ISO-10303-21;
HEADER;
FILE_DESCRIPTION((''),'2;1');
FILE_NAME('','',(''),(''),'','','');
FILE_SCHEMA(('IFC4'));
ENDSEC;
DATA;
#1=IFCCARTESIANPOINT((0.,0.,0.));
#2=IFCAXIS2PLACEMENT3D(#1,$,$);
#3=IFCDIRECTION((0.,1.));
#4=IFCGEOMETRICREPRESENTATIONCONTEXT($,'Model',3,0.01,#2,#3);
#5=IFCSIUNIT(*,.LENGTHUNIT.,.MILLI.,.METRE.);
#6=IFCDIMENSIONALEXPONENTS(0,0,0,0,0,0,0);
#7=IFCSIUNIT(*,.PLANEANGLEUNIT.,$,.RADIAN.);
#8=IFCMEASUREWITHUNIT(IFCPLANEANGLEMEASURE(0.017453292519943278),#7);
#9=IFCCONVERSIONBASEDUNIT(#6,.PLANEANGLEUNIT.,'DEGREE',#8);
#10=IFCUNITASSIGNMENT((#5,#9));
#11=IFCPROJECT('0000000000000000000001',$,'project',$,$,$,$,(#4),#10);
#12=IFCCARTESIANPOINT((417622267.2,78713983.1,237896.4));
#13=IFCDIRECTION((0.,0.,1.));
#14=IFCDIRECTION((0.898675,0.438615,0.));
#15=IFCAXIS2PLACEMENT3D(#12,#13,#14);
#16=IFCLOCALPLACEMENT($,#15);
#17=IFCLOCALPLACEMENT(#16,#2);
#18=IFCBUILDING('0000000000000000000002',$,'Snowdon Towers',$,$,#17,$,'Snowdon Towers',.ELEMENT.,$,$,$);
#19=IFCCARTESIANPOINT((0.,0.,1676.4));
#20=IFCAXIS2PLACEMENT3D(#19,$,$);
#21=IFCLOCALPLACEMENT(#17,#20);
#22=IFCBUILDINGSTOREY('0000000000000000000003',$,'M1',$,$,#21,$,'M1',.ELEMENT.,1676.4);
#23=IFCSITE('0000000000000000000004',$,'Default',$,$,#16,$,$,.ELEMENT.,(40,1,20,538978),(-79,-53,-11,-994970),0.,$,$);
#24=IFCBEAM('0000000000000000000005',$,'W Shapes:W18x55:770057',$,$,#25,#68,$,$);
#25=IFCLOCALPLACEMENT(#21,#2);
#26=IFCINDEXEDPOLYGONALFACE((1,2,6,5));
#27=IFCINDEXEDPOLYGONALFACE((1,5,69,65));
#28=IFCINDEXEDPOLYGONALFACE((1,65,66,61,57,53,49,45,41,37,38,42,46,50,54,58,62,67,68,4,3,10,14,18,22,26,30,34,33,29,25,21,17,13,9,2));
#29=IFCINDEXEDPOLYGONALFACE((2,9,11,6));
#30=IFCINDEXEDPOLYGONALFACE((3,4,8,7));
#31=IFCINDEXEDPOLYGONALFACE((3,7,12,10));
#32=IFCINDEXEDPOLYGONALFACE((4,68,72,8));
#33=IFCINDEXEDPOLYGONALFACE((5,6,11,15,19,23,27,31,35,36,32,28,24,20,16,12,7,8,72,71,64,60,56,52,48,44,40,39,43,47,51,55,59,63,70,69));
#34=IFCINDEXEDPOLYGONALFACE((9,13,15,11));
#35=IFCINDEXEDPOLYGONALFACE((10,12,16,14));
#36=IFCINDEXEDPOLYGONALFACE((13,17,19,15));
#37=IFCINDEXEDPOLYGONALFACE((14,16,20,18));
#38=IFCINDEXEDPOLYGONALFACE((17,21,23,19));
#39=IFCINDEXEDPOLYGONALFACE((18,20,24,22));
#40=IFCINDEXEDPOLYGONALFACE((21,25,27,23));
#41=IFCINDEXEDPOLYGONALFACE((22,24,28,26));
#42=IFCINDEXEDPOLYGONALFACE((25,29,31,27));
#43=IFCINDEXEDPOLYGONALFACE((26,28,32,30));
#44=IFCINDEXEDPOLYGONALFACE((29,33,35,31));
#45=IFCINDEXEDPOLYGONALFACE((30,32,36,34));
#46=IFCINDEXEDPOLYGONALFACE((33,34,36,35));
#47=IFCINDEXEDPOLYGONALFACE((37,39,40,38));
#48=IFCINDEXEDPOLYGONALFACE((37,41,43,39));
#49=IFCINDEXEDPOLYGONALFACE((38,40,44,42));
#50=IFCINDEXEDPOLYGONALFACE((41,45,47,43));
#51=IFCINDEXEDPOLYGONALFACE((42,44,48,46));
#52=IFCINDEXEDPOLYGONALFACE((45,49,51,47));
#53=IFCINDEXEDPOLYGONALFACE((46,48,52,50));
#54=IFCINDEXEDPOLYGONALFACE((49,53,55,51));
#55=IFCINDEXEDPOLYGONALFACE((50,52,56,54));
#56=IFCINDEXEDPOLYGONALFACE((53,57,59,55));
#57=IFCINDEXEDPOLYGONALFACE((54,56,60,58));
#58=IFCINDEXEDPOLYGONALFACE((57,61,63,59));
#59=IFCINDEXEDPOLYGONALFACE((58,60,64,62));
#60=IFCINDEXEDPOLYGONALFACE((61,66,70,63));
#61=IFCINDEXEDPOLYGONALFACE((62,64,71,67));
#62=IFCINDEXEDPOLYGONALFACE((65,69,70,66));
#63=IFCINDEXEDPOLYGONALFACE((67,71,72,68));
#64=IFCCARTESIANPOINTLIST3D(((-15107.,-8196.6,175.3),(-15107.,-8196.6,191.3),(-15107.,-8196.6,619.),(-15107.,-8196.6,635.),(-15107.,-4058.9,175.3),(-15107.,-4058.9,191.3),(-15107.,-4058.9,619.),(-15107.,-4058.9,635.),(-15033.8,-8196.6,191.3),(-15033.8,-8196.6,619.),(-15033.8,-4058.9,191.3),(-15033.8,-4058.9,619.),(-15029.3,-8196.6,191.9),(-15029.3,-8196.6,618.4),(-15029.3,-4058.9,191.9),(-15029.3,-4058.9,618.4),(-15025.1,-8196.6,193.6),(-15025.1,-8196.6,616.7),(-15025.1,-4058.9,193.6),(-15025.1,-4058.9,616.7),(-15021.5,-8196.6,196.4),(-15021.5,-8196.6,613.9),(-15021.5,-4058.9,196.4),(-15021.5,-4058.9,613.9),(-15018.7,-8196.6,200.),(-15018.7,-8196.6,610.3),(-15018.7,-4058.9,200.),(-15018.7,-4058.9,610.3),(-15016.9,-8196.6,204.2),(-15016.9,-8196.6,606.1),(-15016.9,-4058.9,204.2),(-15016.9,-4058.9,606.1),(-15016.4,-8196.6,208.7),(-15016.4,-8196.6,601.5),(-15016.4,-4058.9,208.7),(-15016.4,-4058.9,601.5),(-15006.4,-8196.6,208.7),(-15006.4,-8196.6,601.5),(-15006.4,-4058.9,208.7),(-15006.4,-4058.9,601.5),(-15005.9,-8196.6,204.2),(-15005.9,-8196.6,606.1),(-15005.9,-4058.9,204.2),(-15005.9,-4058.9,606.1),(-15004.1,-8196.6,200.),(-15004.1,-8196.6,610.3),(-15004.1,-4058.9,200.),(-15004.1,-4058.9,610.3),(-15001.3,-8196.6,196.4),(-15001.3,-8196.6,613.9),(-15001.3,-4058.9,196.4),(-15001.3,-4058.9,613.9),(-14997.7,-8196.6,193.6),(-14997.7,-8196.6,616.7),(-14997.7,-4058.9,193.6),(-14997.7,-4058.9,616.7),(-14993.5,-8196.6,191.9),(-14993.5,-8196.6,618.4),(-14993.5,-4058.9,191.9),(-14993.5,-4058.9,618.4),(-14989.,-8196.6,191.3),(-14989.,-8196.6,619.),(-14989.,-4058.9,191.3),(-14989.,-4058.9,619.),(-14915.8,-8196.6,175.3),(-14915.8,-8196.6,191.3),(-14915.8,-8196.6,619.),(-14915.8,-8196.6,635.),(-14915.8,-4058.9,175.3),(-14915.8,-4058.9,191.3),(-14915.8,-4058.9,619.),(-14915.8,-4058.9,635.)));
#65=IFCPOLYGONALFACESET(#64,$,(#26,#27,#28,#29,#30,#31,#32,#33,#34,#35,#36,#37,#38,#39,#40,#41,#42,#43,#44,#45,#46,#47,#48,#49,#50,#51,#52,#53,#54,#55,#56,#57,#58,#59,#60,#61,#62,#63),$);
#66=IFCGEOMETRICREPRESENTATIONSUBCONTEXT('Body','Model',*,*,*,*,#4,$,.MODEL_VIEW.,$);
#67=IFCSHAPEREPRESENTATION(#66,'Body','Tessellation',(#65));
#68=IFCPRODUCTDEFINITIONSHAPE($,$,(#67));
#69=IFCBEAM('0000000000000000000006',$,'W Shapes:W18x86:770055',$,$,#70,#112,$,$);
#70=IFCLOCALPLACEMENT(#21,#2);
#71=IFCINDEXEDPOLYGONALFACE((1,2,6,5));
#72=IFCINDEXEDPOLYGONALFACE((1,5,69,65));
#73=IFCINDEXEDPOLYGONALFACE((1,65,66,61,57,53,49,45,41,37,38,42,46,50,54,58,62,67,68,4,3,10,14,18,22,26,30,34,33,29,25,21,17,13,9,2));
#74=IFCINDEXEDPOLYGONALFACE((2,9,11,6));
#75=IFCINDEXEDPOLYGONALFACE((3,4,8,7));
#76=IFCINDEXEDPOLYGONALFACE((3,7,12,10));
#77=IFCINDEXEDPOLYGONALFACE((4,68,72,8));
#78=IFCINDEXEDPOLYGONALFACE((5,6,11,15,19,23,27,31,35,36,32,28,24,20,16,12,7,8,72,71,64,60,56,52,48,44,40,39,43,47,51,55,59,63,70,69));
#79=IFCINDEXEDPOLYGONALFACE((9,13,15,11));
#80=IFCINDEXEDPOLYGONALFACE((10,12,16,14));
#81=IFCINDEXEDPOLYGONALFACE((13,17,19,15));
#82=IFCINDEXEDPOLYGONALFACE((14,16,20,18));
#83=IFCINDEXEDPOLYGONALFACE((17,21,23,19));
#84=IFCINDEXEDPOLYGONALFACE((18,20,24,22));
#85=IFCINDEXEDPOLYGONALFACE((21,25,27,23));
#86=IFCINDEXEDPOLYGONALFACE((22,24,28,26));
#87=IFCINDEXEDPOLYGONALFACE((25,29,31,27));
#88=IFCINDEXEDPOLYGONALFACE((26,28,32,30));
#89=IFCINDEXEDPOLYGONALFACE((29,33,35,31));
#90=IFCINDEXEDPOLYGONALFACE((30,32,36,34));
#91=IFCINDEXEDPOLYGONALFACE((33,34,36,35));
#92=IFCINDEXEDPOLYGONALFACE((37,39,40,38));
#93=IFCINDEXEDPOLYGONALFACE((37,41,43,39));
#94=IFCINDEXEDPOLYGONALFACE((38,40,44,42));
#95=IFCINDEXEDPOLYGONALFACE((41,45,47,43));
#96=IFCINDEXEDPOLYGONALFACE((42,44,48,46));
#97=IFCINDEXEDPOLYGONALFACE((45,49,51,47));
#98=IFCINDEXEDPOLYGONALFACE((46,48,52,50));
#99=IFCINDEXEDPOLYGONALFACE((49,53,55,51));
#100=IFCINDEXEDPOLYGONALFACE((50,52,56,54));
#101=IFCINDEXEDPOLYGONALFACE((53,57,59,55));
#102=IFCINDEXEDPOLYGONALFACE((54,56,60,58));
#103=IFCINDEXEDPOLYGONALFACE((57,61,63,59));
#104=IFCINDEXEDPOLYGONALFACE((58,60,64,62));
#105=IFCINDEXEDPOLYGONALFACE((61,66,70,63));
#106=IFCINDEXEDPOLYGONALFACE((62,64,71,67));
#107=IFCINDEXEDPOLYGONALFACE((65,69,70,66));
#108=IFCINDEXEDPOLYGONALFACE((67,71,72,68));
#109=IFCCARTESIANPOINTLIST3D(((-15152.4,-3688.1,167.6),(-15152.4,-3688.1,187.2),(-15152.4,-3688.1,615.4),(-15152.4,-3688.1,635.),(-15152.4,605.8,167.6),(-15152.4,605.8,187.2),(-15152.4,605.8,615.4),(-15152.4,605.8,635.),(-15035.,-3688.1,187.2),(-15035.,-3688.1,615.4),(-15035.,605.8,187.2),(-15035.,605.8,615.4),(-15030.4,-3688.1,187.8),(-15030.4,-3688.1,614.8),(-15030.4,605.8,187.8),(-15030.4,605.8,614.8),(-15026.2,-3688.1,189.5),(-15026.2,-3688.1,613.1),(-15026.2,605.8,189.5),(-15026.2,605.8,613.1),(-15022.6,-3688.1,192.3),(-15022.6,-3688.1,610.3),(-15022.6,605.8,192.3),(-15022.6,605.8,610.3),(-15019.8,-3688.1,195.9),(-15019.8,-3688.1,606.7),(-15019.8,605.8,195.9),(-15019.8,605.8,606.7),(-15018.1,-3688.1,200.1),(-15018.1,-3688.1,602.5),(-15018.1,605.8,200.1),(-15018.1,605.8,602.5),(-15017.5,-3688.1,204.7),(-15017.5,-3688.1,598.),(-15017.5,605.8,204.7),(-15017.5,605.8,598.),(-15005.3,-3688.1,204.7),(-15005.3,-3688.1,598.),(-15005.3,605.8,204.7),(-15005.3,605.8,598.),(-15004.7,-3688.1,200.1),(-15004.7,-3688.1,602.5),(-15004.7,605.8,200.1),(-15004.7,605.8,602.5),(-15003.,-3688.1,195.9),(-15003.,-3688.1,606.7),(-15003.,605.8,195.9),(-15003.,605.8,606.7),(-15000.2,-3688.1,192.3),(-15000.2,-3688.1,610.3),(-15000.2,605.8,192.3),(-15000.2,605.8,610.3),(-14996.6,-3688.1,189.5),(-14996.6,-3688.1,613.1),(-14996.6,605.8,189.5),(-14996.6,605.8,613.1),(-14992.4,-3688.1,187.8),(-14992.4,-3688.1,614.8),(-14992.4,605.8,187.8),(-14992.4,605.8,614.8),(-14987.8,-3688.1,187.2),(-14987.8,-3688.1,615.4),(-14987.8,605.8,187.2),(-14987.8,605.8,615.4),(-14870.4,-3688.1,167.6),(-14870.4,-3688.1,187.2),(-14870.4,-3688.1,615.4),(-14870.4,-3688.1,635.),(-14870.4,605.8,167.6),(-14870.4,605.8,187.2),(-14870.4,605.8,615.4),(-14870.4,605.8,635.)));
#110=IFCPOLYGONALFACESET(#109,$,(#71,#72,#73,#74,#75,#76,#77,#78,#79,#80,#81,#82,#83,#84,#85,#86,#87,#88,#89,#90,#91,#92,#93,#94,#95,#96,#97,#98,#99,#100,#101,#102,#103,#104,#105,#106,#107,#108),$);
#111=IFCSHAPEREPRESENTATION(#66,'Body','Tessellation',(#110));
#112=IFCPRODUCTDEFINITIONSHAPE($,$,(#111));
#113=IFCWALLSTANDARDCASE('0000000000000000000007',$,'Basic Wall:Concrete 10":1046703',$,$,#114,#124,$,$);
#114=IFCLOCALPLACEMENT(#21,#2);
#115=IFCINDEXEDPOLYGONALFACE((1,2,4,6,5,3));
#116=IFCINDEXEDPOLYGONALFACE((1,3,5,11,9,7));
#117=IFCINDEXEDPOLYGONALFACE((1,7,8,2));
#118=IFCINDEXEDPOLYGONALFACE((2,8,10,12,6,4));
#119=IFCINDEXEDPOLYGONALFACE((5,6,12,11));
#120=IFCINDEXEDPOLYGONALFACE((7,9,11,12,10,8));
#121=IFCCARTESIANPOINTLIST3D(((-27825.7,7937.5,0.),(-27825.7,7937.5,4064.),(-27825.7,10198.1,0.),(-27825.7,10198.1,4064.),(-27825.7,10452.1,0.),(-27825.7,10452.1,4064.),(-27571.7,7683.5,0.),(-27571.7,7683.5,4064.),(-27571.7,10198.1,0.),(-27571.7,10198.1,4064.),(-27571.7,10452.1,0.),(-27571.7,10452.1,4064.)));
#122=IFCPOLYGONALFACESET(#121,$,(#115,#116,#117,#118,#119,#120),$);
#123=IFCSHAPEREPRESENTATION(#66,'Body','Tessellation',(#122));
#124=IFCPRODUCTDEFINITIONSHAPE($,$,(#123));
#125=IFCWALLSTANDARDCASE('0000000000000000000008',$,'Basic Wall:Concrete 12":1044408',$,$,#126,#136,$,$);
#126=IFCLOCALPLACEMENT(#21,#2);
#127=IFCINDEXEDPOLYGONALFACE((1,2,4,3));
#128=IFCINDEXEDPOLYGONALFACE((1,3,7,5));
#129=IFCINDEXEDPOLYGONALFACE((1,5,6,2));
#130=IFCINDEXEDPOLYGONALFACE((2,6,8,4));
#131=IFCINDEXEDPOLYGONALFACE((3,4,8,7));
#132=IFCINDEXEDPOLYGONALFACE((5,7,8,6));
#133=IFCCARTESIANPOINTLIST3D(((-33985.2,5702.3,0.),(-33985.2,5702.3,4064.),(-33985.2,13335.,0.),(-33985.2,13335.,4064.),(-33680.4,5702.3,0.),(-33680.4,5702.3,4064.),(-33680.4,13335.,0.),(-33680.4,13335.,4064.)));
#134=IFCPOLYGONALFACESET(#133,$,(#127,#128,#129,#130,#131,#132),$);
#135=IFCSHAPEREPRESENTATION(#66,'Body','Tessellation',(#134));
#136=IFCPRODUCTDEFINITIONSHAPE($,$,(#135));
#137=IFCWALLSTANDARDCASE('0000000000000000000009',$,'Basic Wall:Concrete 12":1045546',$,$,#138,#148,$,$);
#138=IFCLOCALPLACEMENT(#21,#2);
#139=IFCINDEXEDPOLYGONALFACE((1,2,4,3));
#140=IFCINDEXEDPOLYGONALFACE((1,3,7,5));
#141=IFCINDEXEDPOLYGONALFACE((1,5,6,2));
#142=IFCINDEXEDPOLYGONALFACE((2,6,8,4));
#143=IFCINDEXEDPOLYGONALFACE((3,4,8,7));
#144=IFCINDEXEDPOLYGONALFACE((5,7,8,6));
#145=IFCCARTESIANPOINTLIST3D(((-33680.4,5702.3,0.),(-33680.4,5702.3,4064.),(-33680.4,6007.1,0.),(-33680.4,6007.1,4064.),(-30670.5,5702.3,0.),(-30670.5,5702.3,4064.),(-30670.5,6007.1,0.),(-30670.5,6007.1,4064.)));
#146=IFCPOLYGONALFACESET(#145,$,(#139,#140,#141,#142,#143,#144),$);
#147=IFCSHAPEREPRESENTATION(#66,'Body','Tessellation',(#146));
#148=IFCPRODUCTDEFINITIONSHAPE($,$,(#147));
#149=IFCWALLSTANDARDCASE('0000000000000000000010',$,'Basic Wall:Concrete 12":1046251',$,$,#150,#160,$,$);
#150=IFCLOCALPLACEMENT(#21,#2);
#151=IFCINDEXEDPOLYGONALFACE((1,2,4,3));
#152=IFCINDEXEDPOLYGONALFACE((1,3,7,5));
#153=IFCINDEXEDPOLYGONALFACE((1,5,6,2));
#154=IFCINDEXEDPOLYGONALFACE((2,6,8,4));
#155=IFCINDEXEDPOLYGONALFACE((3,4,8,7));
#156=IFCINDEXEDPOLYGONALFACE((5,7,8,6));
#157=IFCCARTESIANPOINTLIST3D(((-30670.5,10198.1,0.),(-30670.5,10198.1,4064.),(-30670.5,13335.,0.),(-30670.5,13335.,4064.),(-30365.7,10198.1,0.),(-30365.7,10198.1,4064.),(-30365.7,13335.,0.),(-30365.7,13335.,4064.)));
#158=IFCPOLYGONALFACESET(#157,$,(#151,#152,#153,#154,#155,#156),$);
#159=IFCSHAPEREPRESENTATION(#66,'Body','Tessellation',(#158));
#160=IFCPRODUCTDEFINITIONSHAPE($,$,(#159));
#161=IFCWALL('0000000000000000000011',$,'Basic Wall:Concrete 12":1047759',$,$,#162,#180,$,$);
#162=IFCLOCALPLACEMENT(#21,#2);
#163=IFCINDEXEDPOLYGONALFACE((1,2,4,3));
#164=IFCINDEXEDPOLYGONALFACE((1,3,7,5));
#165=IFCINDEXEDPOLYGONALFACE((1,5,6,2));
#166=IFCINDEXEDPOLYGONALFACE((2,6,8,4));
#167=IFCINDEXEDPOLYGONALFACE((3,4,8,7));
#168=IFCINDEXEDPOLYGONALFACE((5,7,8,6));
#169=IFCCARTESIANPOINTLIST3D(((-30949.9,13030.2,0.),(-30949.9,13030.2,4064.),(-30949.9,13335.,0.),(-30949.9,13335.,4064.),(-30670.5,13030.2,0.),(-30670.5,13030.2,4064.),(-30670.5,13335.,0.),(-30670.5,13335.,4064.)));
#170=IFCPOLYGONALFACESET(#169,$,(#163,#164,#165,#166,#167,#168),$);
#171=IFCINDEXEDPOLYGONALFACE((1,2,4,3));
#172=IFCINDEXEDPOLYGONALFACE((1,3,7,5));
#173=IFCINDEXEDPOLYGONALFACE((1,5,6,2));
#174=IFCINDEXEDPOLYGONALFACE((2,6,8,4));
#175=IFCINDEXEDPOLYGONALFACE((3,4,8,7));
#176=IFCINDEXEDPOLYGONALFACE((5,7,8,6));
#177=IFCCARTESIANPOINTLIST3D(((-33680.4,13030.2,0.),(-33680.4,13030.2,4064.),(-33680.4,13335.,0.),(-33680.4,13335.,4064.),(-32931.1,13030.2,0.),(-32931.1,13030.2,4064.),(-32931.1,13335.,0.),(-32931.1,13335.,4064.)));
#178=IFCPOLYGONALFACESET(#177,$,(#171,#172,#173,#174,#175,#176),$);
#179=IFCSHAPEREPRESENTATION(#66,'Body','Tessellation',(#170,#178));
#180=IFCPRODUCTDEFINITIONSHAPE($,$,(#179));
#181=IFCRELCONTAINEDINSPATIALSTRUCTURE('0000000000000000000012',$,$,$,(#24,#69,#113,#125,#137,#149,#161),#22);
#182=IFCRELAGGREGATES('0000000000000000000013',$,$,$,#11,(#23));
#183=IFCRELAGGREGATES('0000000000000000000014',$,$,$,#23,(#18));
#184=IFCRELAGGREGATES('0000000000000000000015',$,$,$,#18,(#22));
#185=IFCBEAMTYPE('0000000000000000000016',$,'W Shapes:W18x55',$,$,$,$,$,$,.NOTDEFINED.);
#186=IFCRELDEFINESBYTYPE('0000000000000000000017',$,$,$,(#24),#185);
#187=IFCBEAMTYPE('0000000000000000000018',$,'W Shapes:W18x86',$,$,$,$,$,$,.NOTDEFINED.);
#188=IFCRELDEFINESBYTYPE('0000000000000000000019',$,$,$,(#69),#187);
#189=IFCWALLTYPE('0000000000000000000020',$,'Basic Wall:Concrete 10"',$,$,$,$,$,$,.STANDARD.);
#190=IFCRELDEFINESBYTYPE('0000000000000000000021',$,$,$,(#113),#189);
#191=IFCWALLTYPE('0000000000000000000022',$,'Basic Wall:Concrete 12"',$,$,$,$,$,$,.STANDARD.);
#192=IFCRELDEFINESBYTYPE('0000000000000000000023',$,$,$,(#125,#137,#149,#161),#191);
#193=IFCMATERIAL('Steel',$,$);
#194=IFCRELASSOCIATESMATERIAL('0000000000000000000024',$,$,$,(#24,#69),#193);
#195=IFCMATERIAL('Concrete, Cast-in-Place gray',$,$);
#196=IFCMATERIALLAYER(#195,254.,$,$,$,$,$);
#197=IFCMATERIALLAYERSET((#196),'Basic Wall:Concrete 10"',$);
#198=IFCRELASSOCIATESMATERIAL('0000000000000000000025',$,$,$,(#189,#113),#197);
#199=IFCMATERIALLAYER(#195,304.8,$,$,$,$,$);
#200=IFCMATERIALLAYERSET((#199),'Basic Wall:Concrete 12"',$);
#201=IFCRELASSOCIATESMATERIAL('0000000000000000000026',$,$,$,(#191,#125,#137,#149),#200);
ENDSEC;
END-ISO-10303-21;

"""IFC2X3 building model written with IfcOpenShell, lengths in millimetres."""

from ifc_helpers import new_model, entity, si_unit, converted_unit, direction, frame, frame_2d, origin, place, context, subcontext, project, spatial, polyline, rectangle, i_section, outline, extrude, material, layer, layer_set, layer_usage, type_object, element, save


model = new_model("IFC2X3")

# Units and contexts
model_context = context("Model", 3, precision=0.01, world=origin(), true_north=direction((0.0, 1.0)))
body_context = subcontext(model_context, "Body", "Model", "MODEL_VIEW")
ifc_project = project(units=[si_unit("LENGTHUNIT", "METRE", prefix="MILLI"), converted_unit("PLANEANGLEUNIT", "DEGREE", entity("IfcPlaneAngleMeasure", 0.017453292519943278), si_unit("PLANEANGLEUNIT", "RADIAN"), dimensions=[0, 0, 0, 0, 0, 0, 0])], contexts=[model_context])

# Site, building, storey
site_placement = place(None, frame((417622267.2, 78713983.1, 237896.4), z_axis=(0.0, 0.0, 1.0), x_axis=(0.898675, 0.438615, 0.0)))
site = spatial("IfcSite", under=ifc_project, at=site_placement, Name="Default", CompositionType="ELEMENT", RefLatitude=(40, 1, 20, 538978), RefLongitude=(-79, -53, -11, -994970), RefElevation=0.0)
building_placement = place(site_placement, origin())
building = spatial("IfcBuilding", under=site, at=building_placement, Name="Snowdon Towers", LongName="Snowdon Towers", CompositionType="ELEMENT")
storey_placement = place(building_placement, frame((0.0, 0.0, 1676.4)))
storey = spatial("IfcBuildingStorey", under=building, at=storey_placement, Name="M1", LongName="M1", CompositionType="ELEMENT", Elevation=1676.4)

# Shared definitions
ifc_material_1 = material(Name="Steel")

# Beams
beam_type_1 = type_object("IfcBeamType", Name="W Shapes:W18x55", PredefinedType="NOTDEFINED")
beam_1_placement = place(storey_placement, frame((-15011.4, -3873.5, 635.0), z_axis=(0.0, 0.0, 1.0), x_axis=(0.0, -1.0, 0.0)))
element("IfcBeam", 1, at=beam_1_placement, inside=storey, type_object=beam_type_1, material=ifc_material_1, Name="W Shapes:W18x55:770057", context=body_context, shape_type="SweptSolid", body=[
    extrude(i_section(OverallWidth=191.3, OverallDepth=459.7, WebThickness=9.9, FlangeThickness=16.0, FilletRadius=17.5, at=frame_2d((0.0, 0.0), x_axis=(0.0, 1.0))), frame((185.4, 0.0, -229.9), z_axis=(1.0, 0.0, 0.0), x_axis=(0.0, 0.0, -1.0)), (0.0, 0.0, 1.0), 4137.7),
])
beam_type_2 = type_object("IfcBeamType", Name="W Shapes:W18x86", PredefinedType="NOTDEFINED")
beam_2_placement = place(storey_placement, frame((-15011.4, 762.0, 635.0), z_axis=(0.0, 0.0, 1.0), x_axis=(0.0, -1.0, 0.0)))
element("IfcBeam", 2, at=beam_2_placement, inside=storey, type_object=beam_type_2, material=ifc_material_1, Name="W Shapes:W18x86:770055", context=body_context, shape_type="SweptSolid", body=[
    extrude(i_section(OverallWidth=281.9, OverallDepth=467.4, WebThickness=12.2, FlangeThickness=19.6, FilletRadius=17.5, at=frame_2d((0.0, 0.0), x_axis=(0.0, 1.0))), frame((156.2, 0.0, -233.7), z_axis=(1.0, 0.0, 0.0), x_axis=(0.0, 0.0, -1.0)), (0.0, 0.0, 1.0), 4293.9),
])

# Walls
ifc_material_2 = material(Name="Concrete, Cast-in-Place gray")
ifc_layer_1 = layer(ifc_material_2, 254.0)
ifc_layer_set_1 = layer_set([ifc_layer_1], Name="Basic Wall:Concrete 10\"")
ifc_layer_usage_1 = layer_usage(ifc_layer_set_1, "AXIS2", "POSITIVE", -127.0)
wall_type_1 = type_object("IfcWallType", Name="Basic Wall:Concrete 10\"", PredefinedType="STANDARD", material=ifc_layer_set_1)
wall_1_placement = place(storey_placement, frame((-27698.7, 10452.1, 0.0), z_axis=(0.0, 0.0, 1.0), x_axis=(0.0, -1.0, 0.0)))
element("IfcWallStandardCase", 3, at=wall_1_placement, inside=storey, type_object=wall_type_1, material=ifc_layer_usage_1, Name="Basic Wall:Concrete 10\":1046703", context=body_context, shape_type="SweptSolid", body=[
    extrude(outline(polyline([(2514.6, -127.0), (2768.6, 127.0), (254.0, 127.0), (0.0, 127.0), (0.0, -127.0), (254.0, -127.0), (2514.6, -127.0)])), origin(), (0.0, 0.0, 1.0), 4064.0),
])
ifc_layer_2 = layer(ifc_material_2, 304.8)
ifc_layer_set_2 = layer_set([ifc_layer_2], Name="Basic Wall:Concrete 12\"")
ifc_layer_usage_2 = layer_usage(ifc_layer_set_2, "AXIS2", "POSITIVE", -152.4)
wall_type_2 = type_object("IfcWallType", Name="Basic Wall:Concrete 12\"", PredefinedType="STANDARD", material=ifc_layer_set_2)
wall_2_placement = place(storey_placement, frame((-33832.8, 13335.0, 0.0), z_axis=(0.0, 0.0, 1.0), x_axis=(0.0, -1.0, 0.0)))
element("IfcWallStandardCase", 4, at=wall_2_placement, inside=storey, type_object=wall_type_2, material=ifc_layer_usage_2, Name="Basic Wall:Concrete 12\":1044408", context=body_context, shape_type="SweptSolid", body=[
    extrude(rectangle(XDim=7632.7, YDim=304.8, at=frame_2d((3816.4, 0.0), x_axis=(-1.0, 0.0))), origin(), (0.0, 0.0, 1.0), 4064.0),
])
ifc_layer_usage_3 = layer_usage(ifc_layer_set_2, "AXIS2", "POSITIVE", -152.4)
wall_3_placement = place(storey_placement, frame((-30670.5, 5854.7, 0.0), z_axis=(0.0, 0.0, 1.0), x_axis=(-1.0, 0.0, 0.0)))
element("IfcWallStandardCase", 5, at=wall_3_placement, inside=storey, type_object=wall_type_2, material=ifc_layer_usage_3, Name="Basic Wall:Concrete 12\":1045546", context=body_context, shape_type="SweptSolid", body=[
    extrude(rectangle(XDim=3009.9, YDim=304.8, at=frame_2d((1505.0, 0.0), x_axis=(-1.0, 0.0))), origin(), (0.0, 0.0, 1.0), 4064.0),
])
ifc_layer_usage_4 = layer_usage(ifc_layer_set_2, "AXIS2", "NEGATIVE", 152.4)
wall_4_placement = place(storey_placement, frame((-30518.1, 10198.1, 0.0), z_axis=(0.0, 0.0, 1.0), x_axis=(0.0, 1.0, 0.0)))
element("IfcWallStandardCase", 6, at=wall_4_placement, inside=storey, type_object=wall_type_2, material=ifc_layer_usage_4, Name="Basic Wall:Concrete 12\":1046251", context=body_context, shape_type="SweptSolid", body=[
    extrude(rectangle(XDim=3136.9, YDim=304.8, at=frame_2d((1568.5, 0.0), x_axis=(-1.0, 0.0))), origin(), (0.0, 0.0, 1.0), 4064.0),
])
wall_5_placement = place(storey_placement, frame((-30670.5, 13182.6, 0.0), z_axis=(0.0, 0.0, 1.0), x_axis=(-1.0, 0.0, 0.0)))
element("IfcWall", 7, at=wall_5_placement, inside=storey, type_object=wall_type_2, Name="Basic Wall:Concrete 12\":1047759", context=body_context, shape_type="SweptSolid", body=[
    extrude(rectangle(XDim=304.8, YDim=279.4, at=frame_2d((0.0, 0.0), x_axis=(1.0, 0.0))), frame((139.7, 0.0, 0.0), z_axis=(0.0, 0.0, 1.0), x_axis=(0.0, 1.0, 0.0)), (0.0, 0.0, 1.0), 4064.0),
    extrude(rectangle(XDim=304.8, YDim=749.3, at=frame_2d((0.0, 0.0), x_axis=(1.0, 0.0))), frame((2635.3, 0.0, 0.0), z_axis=(0.0, 0.0, 1.0), x_axis=(0.0, 1.0, 0.0)), (0.0, 0.0, 1.0), 4064.0),
])

save(model, "model.ifc")
